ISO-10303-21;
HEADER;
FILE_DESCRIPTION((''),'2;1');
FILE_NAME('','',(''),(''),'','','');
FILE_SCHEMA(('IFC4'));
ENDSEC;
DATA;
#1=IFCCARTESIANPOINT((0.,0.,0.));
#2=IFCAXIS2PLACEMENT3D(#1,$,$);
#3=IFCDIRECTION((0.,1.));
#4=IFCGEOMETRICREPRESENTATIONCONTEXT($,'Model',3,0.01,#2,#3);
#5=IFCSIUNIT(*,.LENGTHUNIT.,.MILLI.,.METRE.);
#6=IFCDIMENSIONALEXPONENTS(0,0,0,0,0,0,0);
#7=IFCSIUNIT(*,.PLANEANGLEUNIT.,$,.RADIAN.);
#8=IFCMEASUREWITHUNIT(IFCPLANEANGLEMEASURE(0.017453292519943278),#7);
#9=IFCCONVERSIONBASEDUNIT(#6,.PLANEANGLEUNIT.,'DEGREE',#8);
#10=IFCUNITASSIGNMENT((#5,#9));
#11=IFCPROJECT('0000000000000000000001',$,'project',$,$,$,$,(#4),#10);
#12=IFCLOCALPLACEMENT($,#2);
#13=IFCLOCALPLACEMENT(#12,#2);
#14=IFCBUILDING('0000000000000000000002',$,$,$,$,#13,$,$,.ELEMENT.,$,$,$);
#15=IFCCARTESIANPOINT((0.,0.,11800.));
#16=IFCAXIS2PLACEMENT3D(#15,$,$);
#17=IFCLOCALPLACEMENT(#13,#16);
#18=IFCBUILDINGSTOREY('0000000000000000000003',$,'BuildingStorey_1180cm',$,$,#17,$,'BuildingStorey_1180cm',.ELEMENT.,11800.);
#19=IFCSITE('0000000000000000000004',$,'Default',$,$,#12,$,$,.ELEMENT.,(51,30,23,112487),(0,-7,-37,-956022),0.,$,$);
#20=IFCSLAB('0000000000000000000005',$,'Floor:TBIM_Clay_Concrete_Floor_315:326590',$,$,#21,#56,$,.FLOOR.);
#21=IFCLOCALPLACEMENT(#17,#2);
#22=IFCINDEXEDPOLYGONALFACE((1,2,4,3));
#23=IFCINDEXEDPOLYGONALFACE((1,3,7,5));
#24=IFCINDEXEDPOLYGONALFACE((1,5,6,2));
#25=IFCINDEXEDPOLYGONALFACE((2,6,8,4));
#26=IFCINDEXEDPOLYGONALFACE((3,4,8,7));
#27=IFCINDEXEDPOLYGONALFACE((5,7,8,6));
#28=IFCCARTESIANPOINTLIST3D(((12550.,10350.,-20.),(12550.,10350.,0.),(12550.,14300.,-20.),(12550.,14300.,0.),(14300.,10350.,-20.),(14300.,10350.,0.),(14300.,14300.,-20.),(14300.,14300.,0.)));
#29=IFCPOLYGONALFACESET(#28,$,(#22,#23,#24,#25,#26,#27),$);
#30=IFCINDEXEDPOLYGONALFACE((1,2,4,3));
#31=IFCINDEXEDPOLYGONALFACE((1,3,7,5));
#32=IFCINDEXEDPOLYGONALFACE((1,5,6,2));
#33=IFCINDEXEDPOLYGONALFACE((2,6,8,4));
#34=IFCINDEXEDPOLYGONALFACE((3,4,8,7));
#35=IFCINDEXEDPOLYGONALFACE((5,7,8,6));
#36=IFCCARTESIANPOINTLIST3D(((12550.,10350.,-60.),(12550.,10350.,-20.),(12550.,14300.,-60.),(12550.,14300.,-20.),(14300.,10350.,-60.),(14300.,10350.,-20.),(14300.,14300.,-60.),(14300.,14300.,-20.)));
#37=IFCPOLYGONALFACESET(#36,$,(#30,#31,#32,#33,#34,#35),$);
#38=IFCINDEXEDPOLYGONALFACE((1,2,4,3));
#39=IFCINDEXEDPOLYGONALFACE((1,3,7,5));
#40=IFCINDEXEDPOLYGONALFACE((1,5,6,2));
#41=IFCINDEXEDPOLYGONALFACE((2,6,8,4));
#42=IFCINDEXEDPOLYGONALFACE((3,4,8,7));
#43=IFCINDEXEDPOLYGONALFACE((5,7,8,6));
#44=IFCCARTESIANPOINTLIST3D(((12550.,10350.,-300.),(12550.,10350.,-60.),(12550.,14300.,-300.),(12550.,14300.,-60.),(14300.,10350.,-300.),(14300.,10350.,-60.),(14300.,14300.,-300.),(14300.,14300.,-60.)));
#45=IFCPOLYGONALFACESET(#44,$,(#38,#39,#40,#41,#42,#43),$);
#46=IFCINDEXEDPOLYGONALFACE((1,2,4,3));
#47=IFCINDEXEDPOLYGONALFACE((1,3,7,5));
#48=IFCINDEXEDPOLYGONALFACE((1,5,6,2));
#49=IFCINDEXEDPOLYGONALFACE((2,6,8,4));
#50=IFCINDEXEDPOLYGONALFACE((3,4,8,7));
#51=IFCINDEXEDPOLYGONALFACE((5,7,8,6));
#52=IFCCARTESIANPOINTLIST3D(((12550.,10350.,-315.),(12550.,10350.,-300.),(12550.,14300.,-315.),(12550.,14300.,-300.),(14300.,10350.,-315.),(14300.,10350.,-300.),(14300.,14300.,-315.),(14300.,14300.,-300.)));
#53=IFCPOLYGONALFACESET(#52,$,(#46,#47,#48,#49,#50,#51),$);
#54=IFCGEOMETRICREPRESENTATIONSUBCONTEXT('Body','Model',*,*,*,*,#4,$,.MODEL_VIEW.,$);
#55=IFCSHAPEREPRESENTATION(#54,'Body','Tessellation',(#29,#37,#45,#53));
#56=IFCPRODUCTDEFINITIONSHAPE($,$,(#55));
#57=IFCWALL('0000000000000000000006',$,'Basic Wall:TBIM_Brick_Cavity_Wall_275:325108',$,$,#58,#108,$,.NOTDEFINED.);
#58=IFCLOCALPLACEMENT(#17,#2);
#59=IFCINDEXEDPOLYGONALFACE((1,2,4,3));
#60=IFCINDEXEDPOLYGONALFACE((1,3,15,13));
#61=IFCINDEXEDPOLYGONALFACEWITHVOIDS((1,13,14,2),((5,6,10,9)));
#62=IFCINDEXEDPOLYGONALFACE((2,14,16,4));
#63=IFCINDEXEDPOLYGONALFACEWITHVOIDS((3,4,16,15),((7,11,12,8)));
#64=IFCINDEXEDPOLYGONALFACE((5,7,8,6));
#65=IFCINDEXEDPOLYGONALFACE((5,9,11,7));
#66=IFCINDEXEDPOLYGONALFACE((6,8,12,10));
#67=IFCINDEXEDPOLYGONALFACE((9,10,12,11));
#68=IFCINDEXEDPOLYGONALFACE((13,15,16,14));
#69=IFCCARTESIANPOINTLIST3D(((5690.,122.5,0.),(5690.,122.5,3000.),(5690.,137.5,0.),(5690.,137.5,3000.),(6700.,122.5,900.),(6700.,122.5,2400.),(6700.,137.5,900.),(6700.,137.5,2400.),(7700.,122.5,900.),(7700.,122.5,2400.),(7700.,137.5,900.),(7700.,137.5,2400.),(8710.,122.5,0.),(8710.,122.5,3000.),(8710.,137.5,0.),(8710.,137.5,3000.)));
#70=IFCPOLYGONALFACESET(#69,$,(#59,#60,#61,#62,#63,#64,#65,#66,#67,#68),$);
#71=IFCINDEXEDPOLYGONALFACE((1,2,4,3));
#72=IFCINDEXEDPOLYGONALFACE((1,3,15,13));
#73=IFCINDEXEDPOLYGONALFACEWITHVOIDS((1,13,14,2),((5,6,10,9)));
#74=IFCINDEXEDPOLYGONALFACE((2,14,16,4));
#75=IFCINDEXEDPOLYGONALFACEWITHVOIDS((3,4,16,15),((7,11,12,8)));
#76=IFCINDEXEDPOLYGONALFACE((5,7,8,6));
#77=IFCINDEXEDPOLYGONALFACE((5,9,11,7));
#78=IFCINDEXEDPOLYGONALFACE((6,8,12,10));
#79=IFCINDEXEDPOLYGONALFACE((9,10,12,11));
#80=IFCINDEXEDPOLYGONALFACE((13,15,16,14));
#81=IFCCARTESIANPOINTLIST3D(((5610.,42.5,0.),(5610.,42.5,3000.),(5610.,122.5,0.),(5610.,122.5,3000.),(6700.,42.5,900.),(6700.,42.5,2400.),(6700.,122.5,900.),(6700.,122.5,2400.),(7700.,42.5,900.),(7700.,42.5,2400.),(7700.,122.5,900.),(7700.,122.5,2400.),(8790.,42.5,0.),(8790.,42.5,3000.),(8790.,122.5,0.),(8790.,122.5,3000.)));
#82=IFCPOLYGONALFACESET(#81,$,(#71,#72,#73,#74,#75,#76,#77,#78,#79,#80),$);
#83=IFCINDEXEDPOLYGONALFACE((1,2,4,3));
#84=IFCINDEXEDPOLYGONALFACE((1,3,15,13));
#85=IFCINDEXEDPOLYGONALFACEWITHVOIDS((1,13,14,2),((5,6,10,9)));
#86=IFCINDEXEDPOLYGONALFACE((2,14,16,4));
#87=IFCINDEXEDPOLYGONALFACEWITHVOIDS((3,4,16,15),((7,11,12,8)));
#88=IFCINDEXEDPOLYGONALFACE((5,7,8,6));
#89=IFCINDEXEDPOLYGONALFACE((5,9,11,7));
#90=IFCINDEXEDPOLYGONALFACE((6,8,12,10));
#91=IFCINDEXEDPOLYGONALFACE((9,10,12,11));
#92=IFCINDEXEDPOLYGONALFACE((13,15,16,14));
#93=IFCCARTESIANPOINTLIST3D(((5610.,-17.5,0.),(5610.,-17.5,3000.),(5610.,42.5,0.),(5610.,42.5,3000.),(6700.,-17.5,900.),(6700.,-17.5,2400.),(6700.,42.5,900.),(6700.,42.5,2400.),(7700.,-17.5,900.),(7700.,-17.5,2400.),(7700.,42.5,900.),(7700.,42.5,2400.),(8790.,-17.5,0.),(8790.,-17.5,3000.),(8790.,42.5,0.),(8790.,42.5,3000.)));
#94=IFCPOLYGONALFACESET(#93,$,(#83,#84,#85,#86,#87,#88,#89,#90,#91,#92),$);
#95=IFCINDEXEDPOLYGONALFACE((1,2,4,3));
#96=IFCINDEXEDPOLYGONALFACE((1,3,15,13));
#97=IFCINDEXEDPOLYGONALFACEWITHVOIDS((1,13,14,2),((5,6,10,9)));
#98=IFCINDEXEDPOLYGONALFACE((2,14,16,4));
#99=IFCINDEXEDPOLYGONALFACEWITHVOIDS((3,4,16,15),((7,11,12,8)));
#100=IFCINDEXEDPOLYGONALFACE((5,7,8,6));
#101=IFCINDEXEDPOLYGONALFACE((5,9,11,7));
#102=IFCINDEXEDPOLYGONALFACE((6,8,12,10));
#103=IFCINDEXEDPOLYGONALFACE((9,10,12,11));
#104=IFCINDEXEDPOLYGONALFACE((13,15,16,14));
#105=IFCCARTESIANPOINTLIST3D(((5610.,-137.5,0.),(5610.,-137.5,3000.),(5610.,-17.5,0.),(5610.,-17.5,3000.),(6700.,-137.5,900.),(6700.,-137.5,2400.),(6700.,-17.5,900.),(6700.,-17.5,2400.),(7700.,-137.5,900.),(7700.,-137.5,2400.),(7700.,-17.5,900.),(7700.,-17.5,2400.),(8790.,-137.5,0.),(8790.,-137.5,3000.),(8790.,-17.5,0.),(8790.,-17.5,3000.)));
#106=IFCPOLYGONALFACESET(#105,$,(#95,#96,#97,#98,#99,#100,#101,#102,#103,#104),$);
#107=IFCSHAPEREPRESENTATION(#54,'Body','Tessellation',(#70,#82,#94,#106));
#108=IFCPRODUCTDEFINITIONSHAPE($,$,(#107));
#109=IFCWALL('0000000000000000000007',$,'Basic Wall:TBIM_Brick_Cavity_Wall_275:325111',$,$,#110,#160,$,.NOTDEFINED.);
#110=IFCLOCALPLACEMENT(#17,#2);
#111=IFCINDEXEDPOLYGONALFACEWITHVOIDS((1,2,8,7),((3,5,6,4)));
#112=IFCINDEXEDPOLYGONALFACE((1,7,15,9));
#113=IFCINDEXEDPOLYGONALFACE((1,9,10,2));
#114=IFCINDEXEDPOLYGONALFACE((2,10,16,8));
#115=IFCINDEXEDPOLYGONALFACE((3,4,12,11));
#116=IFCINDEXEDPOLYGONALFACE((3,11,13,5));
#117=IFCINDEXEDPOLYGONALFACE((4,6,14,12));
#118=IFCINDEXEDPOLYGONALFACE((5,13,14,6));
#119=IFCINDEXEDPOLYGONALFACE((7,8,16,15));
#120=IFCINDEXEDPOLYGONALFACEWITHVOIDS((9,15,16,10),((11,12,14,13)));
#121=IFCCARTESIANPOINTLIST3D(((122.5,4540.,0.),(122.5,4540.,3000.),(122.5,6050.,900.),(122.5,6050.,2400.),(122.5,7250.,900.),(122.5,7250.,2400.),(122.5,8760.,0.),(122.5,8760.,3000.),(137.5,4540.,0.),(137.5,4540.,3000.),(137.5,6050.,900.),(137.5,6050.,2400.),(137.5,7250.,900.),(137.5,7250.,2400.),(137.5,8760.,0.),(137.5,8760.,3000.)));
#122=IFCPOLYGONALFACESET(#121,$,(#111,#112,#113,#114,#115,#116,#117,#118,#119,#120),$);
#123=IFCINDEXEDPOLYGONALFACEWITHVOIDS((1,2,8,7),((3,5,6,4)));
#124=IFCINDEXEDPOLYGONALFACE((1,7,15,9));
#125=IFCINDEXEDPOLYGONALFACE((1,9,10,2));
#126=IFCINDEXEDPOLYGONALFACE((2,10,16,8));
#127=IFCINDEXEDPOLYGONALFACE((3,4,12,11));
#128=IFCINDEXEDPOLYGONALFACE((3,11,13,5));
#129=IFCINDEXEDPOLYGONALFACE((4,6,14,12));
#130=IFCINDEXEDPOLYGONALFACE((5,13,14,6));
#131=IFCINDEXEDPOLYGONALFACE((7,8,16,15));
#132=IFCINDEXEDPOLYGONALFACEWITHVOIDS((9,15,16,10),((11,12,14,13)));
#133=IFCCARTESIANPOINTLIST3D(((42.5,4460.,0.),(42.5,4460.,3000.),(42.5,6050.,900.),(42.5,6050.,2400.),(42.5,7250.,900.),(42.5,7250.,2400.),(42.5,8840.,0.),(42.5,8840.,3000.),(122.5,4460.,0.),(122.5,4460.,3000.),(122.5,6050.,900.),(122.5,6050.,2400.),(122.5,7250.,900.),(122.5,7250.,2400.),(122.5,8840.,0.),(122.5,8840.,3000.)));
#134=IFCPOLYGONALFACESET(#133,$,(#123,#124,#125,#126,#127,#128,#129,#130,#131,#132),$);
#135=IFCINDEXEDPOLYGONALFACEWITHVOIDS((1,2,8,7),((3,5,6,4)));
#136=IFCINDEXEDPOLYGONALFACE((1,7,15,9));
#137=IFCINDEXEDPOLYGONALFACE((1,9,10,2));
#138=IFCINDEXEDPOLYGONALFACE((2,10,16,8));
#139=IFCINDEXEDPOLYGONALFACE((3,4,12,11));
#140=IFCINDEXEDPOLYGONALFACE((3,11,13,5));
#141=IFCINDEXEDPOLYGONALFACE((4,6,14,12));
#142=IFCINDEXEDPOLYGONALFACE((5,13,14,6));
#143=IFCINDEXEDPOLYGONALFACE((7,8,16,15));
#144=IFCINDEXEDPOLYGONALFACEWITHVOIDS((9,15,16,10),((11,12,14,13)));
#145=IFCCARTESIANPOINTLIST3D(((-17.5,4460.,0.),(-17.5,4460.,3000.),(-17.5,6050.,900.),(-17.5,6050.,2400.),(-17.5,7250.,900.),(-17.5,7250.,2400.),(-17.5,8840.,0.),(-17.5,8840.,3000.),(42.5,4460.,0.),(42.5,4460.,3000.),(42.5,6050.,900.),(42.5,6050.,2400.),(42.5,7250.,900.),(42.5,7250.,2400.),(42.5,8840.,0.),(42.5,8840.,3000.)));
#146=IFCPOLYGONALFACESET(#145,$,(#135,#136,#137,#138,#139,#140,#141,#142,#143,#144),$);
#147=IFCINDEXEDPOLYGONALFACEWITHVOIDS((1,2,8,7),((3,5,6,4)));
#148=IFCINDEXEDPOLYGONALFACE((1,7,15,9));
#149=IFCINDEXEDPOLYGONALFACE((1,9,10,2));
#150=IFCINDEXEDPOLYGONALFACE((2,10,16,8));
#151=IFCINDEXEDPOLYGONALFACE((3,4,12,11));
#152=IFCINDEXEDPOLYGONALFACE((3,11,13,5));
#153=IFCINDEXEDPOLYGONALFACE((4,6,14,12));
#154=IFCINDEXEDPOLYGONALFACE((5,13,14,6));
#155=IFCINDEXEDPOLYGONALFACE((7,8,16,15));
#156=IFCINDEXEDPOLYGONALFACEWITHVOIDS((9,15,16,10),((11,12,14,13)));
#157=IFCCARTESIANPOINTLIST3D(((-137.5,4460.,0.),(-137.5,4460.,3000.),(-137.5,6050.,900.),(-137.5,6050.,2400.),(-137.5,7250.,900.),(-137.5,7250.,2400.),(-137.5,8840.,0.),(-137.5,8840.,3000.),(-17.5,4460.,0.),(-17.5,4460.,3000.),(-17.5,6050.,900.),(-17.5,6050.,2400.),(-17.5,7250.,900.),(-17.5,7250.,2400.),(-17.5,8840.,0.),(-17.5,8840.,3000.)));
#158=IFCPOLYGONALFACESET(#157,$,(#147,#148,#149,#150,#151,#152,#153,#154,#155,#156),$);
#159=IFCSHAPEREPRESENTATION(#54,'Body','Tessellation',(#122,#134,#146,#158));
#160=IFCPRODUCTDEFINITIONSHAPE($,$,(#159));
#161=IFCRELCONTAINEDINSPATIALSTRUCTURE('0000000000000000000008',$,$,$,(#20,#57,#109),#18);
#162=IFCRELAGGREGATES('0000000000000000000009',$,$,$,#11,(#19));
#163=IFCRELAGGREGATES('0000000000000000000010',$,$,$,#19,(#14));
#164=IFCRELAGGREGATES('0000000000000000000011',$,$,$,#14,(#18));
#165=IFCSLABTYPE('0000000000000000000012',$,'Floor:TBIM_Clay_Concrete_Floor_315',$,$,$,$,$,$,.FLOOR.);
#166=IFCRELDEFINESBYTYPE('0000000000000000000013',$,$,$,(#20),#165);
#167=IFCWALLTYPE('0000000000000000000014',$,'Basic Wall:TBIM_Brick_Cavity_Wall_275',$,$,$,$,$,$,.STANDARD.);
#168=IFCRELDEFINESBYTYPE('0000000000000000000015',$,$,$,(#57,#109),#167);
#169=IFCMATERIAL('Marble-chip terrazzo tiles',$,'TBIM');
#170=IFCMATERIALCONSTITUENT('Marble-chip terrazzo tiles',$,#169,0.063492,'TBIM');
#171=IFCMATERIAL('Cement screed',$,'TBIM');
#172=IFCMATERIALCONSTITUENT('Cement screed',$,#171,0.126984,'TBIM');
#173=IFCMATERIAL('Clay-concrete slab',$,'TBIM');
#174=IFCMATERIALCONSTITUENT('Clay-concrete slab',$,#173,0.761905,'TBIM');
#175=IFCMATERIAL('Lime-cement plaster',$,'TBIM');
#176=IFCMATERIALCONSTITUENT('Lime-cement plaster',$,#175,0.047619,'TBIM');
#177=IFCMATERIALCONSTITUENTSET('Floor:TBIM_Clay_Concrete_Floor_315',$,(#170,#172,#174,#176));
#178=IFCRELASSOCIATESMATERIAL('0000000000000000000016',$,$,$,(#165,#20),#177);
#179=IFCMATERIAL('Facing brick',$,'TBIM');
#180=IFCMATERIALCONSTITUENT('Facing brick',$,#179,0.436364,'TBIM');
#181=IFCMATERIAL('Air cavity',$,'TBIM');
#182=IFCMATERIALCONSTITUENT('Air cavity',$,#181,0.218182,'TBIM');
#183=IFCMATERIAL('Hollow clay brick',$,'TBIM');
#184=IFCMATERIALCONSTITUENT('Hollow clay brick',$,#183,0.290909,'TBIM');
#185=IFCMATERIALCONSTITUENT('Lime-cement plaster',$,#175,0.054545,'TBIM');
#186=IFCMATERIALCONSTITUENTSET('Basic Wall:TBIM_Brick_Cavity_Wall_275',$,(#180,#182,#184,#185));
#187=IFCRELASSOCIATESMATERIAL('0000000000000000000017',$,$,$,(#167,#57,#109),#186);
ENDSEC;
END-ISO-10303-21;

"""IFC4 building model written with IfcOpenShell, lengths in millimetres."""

from ifc_helpers import new_model, entity, si_unit, converted_unit, direction, frame, origin, place, context, subcontext, project, spatial, indexed_curve, outline, extrude, material, constituent, constituent_set, type_object, element, save


model = new_model("IFC4")

# Units and contexts
model_context = context("Model", 3, precision=0.01, world=origin(), true_north=direction((0.0, 1.0)))
body_context = subcontext(model_context, "Body", "Model", "MODEL_VIEW")
ifc_project = project(units=[si_unit("LENGTHUNIT", "METRE", prefix="MILLI"), converted_unit("PLANEANGLEUNIT", "DEGREE", entity("IfcPlaneAngleMeasure", 0.017453292519943278), si_unit("PLANEANGLEUNIT", "RADIAN"), dimensions=[0, 0, 0, 0, 0, 0, 0])], contexts=[model_context])

# Site, building, storey
site_placement = place(None, origin())
site = spatial("IfcSite", under=ifc_project, at=site_placement, Name="Default", CompositionType="ELEMENT", RefLatitude=(51, 30, 23, 112487), RefLongitude=(0, -7, -37, -956022), RefElevation=0.0)
building_placement = place(site_placement, origin())
building = spatial("IfcBuilding", under=site, at=building_placement, CompositionType="ELEMENT")
storey_placement = place(building_placement, frame((0.0, 0.0, 11800.0)))
storey = spatial("IfcBuildingStorey", under=building, at=storey_placement, Name="BuildingStorey_1180cm", LongName="BuildingStorey_1180cm", CompositionType="ELEMENT", Elevation=11800.0)

# Slab
ifc_material_1 = material(Name="Marble-chip terrazzo tiles", Category="TBIM")
ifc_constituent_1 = constituent(ifc_material_1, Name="Marble-chip terrazzo tiles", Category="TBIM", fraction=0.063492)
ifc_material_2 = material(Name="Cement screed", Category="TBIM")
ifc_constituent_2 = constituent(ifc_material_2, Name="Cement screed", Category="TBIM", fraction=0.126984)
ifc_material_3 = material(Name="Clay-concrete slab", Category="TBIM")
ifc_constituent_3 = constituent(ifc_material_3, Name="Clay-concrete slab", Category="TBIM", fraction=0.761905)
ifc_material_4 = material(Name="Lime-cement plaster", Category="TBIM")
ifc_constituent_4 = constituent(ifc_material_4, Name="Lime-cement plaster", Category="TBIM", fraction=0.047619)
ifc_constituent_set_1 = constituent_set(constituents=[ifc_constituent_1, ifc_constituent_2, ifc_constituent_3, ifc_constituent_4], Name="Floor:TBIM_Clay_Concrete_Floor_315")
slab_type = type_object("IfcSlabType", Name="Floor:TBIM_Clay_Concrete_Floor_315", PredefinedType="FLOOR", material=ifc_constituent_set_1)
slab_1_placement = place(storey_placement, origin())
element("IfcSlab", 1, at=slab_1_placement, inside=storey, type_object=slab_type, material=ifc_constituent_set_1, Name="Floor:TBIM_Clay_Concrete_Floor_315:326590", PredefinedType="FLOOR", context=body_context, shape_type="SweptSolid", body=[
    extrude(outline(indexed_curve([(-875.0, -1975.0), (875.0, -1975.0), (875.0, 1975.0), (-875.0, 1975.0), (-875.0, -1975.0)], self_intersect=False)), frame((13425.0, 12325.0, -20.0), z_axis=(0.0, 0.0, 1.0), x_axis=(-1.0, 0.0, 0.0)), (0.0, 0.0, 1.0), 20.0),
    extrude(outline(indexed_curve([(-875.0, -1975.0), (875.0, -1975.0), (875.0, 1975.0), (-875.0, 1975.0), (-875.0, -1975.0)], self_intersect=False)), frame((13425.0, 12325.0, -60.0), z_axis=(0.0, 0.0, 1.0), x_axis=(-1.0, 0.0, 0.0)), (0.0, 0.0, 1.0), 40.0),
    extrude(outline(indexed_curve([(-875.0, -1975.0), (875.0, -1975.0), (875.0, 1975.0), (-875.0, 1975.0), (-875.0, -1975.0)], self_intersect=False)), frame((13425.0, 12325.0, -300.0), z_axis=(0.0, 0.0, 1.0), x_axis=(-1.0, 0.0, 0.0)), (0.0, 0.0, 1.0), 240.0),
    extrude(outline(indexed_curve([(-875.0, -1975.0), (875.0, -1975.0), (875.0, 1975.0), (-875.0, 1975.0), (-875.0, -1975.0)], self_intersect=False)), frame((13425.0, 12325.0, -315.0), z_axis=(0.0, 0.0, 1.0), x_axis=(-1.0, 0.0, 0.0)), (0.0, 0.0, 1.0), 15.0),
])

# Walls, openings
ifc_material_5 = material(Name="Facing brick", Category="TBIM")
ifc_constituent_5 = constituent(ifc_material_5, Name="Facing brick", Category="TBIM", fraction=0.436364)
ifc_material_6 = material(Name="Air cavity", Category="TBIM")
ifc_constituent_6 = constituent(ifc_material_6, Name="Air cavity", Category="TBIM", fraction=0.218182)
ifc_material_7 = material(Name="Hollow clay brick", Category="TBIM")
ifc_constituent_7 = constituent(ifc_material_7, Name="Hollow clay brick", Category="TBIM", fraction=0.290909)
ifc_constituent_8 = constituent(ifc_material_4, Name="Lime-cement plaster", Category="TBIM", fraction=0.054545)
ifc_constituent_set_2 = constituent_set(constituents=[ifc_constituent_5, ifc_constituent_6, ifc_constituent_7, ifc_constituent_8], Name="Basic Wall:TBIM_Brick_Cavity_Wall_275")
wall_type_1 = type_object("IfcWallType", Name="Basic Wall:TBIM_Brick_Cavity_Wall_275", PredefinedType="STANDARD", material=ifc_constituent_set_2)
wall_1_placement = place(storey_placement, frame((5595.0, 0.0, 0.0)))
wall_1 = element("IfcWall", 2, at=wall_1_placement, inside=storey, type_object=wall_type_1, material=ifc_constituent_set_2, Name="Basic Wall:TBIM_Brick_Cavity_Wall_275:325108", PredefinedType="NOTDEFINED", context=body_context, shape_type="SweptSolid", body=[
    extrude(outline(indexed_curve([(-1500.0, -1510.0), (1500.0, -1510.0), (1500.0, 1510.0), (-1500.0, 1510.0), (-1500.0, -1510.0)], self_intersect=False), holes=[indexed_curve([(-600.0, -500.0), (-600.0, 500.0), (900.0, 500.0), (900.0, -500.0), (-600.0, -500.0)], self_intersect=False)]), frame((1605.0, 122.5, 1500.0), z_axis=(0.0, 1.0, 0.0), x_axis=(0.0, 0.0, 1.0)), (0.0, 0.0, 1.0), 15.0),
    extrude(outline(indexed_curve([(-1500.0, -1590.0), (1500.0, -1590.0), (1500.0, 1590.0), (-1500.0, 1590.0), (-1500.0, -1590.0)], self_intersect=False), holes=[indexed_curve([(-600.0, -500.0), (-600.0, 500.0), (900.0, 500.0), (900.0, -500.0), (-600.0, -500.0)], self_intersect=False)]), frame((1605.0, 42.5, 1500.0), z_axis=(0.0, 1.0, 0.0), x_axis=(0.0, 0.0, 1.0)), (0.0, 0.0, 1.0), 80.0),
    extrude(outline(indexed_curve([(-1500.0, -1590.0), (1500.0, -1590.0), (1500.0, 1590.0), (-1500.0, 1590.0), (-1500.0, -1590.0)], self_intersect=False), holes=[indexed_curve([(-600.0, -500.0), (-600.0, 500.0), (900.0, 500.0), (900.0, -500.0), (-600.0, -500.0)], self_intersect=False)]), frame((1605.0, -17.5, 1500.0), z_axis=(0.0, 1.0, 0.0), x_axis=(0.0, 0.0, 1.0)), (0.0, 0.0, 1.0), 60.0),
    extrude(outline(indexed_curve([(-1500.0, -1590.0), (1500.0, -1590.0), (1500.0, 1590.0), (-1500.0, 1590.0), (-1500.0, -1590.0)], self_intersect=False), holes=[indexed_curve([(900.0, -500.0), (-600.0, -500.0), (-600.0, 500.0), (900.0, 500.0), (900.0, -500.0)], self_intersect=False)]), frame((1605.0, -137.5, 1500.0), z_axis=(0.0, 1.0, 0.0), x_axis=(0.0, 0.0, 1.0)), (0.0, 0.0, 1.0), 120.0),
])
opening_1_placement = place(wall_1_placement, frame((1105.0, -137.5, 900.0)))
element("IfcOpeningElement", 3, at=opening_1_placement, cuts=wall_1, PredefinedType="OPENING", context=body_context, shape_type="SweptSolid", body=[
    extrude(outline(indexed_curve([(1500.0, 0.0), (1500.0, 1000.0), (0.0, 1000.0), (0.0, 0.0), (1500.0, 0.0)], self_intersect=False)), frame((0.0, 0.0, 0.0), z_axis=(0.0, 1.0, 0.0), x_axis=(0.0, 0.0, 1.0)), (0.0, 0.0, 1.0), 275.0),
])
wall_2_placement = place(storey_placement, frame((0.0, 4445.0, 0.0), z_axis=(0.0, 0.0, 1.0), x_axis=(0.0, 1.0, 0.0)))
wall_2 = element("IfcWall", 4, at=wall_2_placement, inside=storey, type_object=wall_type_1, material=ifc_constituent_set_2, Name="Basic Wall:TBIM_Brick_Cavity_Wall_275:325111", PredefinedType="NOTDEFINED", context=body_context, shape_type="SweptSolid", body=[
    extrude(outline(indexed_curve([(-1500.0, -2110.0), (1500.0, -2110.0), (1500.0, 2110.0), (-1500.0, 2110.0), (-1500.0, -2110.0)], self_intersect=False), holes=[indexed_curve([(900.0, 600.0), (900.0, -600.0), (-600.0, -600.0), (-600.0, 600.0), (900.0, 600.0)], self_intersect=False)]), frame((2205.0, -122.5, 1500.0), z_axis=(0.0, -1.0, 0.0), x_axis=(0.0, 0.0, 1.0)), (0.0, 0.0, 1.0), 15.0),
    extrude(outline(indexed_curve([(-1500.0, -2190.0), (1500.0, -2190.0), (1500.0, 2190.0), (-1500.0, 2190.0), (-1500.0, -2190.0)], self_intersect=False), holes=[indexed_curve([(900.0, 600.0), (900.0, -600.0), (-600.0, -600.0), (-600.0, 600.0), (900.0, 600.0)], self_intersect=False)]), frame((2205.0, -42.5, 1500.0), z_axis=(0.0, -1.0, 0.0), x_axis=(0.0, 0.0, 1.0)), (0.0, 0.0, 1.0), 80.0),
    extrude(outline(indexed_curve([(-1500.0, -2190.0), (1500.0, -2190.0), (1500.0, 2190.0), (-1500.0, 2190.0), (-1500.0, -2190.0)], self_intersect=False), holes=[indexed_curve([(900.0, 600.0), (900.0, -600.0), (-600.0, -600.0), (-600.0, 600.0), (900.0, 600.0)], self_intersect=False)]), frame((2205.0, 17.5, 1500.0), z_axis=(0.0, -1.0, 0.0), x_axis=(0.0, 0.0, 1.0)), (0.0, 0.0, 1.0), 60.0),
    extrude(outline(indexed_curve([(-2190.0, -1500.0), (2190.0, -1500.0), (2190.0, 1500.0), (-2190.0, 1500.0), (-2190.0, -1500.0)], self_intersect=False), holes=[indexed_curve([(-600.0, 900.0), (600.0, 900.0), (600.0, -600.0), (-600.0, -600.0), (-600.0, 900.0)], self_intersect=False)]), frame((2205.0, 137.5, 1500.0), z_axis=(0.0, -1.0, 0.0), x_axis=(1.0, 0.0, 0.0)), (0.0, 0.0, 1.0), 120.0),
])
opening_2_placement = place(wall_2_placement, frame((1605.0, -137.5, 900.0)))
element("IfcOpeningElement", 5, at=opening_2_placement, cuts=wall_2, PredefinedType="OPENING", context=body_context, shape_type="SweptSolid", body=[
    extrude(outline(indexed_curve([(1500.0, 0.0), (1500.0, 1200.0), (0.0, 1200.0), (0.0, 0.0), (1500.0, 0.0)], self_intersect=False)), frame((0.0, 0.0, 0.0), z_axis=(0.0, 1.0, 0.0), x_axis=(0.0, 0.0, 1.0)), (0.0, 0.0, 1.0), 275.0),
])

save(model, "model.ifc")
